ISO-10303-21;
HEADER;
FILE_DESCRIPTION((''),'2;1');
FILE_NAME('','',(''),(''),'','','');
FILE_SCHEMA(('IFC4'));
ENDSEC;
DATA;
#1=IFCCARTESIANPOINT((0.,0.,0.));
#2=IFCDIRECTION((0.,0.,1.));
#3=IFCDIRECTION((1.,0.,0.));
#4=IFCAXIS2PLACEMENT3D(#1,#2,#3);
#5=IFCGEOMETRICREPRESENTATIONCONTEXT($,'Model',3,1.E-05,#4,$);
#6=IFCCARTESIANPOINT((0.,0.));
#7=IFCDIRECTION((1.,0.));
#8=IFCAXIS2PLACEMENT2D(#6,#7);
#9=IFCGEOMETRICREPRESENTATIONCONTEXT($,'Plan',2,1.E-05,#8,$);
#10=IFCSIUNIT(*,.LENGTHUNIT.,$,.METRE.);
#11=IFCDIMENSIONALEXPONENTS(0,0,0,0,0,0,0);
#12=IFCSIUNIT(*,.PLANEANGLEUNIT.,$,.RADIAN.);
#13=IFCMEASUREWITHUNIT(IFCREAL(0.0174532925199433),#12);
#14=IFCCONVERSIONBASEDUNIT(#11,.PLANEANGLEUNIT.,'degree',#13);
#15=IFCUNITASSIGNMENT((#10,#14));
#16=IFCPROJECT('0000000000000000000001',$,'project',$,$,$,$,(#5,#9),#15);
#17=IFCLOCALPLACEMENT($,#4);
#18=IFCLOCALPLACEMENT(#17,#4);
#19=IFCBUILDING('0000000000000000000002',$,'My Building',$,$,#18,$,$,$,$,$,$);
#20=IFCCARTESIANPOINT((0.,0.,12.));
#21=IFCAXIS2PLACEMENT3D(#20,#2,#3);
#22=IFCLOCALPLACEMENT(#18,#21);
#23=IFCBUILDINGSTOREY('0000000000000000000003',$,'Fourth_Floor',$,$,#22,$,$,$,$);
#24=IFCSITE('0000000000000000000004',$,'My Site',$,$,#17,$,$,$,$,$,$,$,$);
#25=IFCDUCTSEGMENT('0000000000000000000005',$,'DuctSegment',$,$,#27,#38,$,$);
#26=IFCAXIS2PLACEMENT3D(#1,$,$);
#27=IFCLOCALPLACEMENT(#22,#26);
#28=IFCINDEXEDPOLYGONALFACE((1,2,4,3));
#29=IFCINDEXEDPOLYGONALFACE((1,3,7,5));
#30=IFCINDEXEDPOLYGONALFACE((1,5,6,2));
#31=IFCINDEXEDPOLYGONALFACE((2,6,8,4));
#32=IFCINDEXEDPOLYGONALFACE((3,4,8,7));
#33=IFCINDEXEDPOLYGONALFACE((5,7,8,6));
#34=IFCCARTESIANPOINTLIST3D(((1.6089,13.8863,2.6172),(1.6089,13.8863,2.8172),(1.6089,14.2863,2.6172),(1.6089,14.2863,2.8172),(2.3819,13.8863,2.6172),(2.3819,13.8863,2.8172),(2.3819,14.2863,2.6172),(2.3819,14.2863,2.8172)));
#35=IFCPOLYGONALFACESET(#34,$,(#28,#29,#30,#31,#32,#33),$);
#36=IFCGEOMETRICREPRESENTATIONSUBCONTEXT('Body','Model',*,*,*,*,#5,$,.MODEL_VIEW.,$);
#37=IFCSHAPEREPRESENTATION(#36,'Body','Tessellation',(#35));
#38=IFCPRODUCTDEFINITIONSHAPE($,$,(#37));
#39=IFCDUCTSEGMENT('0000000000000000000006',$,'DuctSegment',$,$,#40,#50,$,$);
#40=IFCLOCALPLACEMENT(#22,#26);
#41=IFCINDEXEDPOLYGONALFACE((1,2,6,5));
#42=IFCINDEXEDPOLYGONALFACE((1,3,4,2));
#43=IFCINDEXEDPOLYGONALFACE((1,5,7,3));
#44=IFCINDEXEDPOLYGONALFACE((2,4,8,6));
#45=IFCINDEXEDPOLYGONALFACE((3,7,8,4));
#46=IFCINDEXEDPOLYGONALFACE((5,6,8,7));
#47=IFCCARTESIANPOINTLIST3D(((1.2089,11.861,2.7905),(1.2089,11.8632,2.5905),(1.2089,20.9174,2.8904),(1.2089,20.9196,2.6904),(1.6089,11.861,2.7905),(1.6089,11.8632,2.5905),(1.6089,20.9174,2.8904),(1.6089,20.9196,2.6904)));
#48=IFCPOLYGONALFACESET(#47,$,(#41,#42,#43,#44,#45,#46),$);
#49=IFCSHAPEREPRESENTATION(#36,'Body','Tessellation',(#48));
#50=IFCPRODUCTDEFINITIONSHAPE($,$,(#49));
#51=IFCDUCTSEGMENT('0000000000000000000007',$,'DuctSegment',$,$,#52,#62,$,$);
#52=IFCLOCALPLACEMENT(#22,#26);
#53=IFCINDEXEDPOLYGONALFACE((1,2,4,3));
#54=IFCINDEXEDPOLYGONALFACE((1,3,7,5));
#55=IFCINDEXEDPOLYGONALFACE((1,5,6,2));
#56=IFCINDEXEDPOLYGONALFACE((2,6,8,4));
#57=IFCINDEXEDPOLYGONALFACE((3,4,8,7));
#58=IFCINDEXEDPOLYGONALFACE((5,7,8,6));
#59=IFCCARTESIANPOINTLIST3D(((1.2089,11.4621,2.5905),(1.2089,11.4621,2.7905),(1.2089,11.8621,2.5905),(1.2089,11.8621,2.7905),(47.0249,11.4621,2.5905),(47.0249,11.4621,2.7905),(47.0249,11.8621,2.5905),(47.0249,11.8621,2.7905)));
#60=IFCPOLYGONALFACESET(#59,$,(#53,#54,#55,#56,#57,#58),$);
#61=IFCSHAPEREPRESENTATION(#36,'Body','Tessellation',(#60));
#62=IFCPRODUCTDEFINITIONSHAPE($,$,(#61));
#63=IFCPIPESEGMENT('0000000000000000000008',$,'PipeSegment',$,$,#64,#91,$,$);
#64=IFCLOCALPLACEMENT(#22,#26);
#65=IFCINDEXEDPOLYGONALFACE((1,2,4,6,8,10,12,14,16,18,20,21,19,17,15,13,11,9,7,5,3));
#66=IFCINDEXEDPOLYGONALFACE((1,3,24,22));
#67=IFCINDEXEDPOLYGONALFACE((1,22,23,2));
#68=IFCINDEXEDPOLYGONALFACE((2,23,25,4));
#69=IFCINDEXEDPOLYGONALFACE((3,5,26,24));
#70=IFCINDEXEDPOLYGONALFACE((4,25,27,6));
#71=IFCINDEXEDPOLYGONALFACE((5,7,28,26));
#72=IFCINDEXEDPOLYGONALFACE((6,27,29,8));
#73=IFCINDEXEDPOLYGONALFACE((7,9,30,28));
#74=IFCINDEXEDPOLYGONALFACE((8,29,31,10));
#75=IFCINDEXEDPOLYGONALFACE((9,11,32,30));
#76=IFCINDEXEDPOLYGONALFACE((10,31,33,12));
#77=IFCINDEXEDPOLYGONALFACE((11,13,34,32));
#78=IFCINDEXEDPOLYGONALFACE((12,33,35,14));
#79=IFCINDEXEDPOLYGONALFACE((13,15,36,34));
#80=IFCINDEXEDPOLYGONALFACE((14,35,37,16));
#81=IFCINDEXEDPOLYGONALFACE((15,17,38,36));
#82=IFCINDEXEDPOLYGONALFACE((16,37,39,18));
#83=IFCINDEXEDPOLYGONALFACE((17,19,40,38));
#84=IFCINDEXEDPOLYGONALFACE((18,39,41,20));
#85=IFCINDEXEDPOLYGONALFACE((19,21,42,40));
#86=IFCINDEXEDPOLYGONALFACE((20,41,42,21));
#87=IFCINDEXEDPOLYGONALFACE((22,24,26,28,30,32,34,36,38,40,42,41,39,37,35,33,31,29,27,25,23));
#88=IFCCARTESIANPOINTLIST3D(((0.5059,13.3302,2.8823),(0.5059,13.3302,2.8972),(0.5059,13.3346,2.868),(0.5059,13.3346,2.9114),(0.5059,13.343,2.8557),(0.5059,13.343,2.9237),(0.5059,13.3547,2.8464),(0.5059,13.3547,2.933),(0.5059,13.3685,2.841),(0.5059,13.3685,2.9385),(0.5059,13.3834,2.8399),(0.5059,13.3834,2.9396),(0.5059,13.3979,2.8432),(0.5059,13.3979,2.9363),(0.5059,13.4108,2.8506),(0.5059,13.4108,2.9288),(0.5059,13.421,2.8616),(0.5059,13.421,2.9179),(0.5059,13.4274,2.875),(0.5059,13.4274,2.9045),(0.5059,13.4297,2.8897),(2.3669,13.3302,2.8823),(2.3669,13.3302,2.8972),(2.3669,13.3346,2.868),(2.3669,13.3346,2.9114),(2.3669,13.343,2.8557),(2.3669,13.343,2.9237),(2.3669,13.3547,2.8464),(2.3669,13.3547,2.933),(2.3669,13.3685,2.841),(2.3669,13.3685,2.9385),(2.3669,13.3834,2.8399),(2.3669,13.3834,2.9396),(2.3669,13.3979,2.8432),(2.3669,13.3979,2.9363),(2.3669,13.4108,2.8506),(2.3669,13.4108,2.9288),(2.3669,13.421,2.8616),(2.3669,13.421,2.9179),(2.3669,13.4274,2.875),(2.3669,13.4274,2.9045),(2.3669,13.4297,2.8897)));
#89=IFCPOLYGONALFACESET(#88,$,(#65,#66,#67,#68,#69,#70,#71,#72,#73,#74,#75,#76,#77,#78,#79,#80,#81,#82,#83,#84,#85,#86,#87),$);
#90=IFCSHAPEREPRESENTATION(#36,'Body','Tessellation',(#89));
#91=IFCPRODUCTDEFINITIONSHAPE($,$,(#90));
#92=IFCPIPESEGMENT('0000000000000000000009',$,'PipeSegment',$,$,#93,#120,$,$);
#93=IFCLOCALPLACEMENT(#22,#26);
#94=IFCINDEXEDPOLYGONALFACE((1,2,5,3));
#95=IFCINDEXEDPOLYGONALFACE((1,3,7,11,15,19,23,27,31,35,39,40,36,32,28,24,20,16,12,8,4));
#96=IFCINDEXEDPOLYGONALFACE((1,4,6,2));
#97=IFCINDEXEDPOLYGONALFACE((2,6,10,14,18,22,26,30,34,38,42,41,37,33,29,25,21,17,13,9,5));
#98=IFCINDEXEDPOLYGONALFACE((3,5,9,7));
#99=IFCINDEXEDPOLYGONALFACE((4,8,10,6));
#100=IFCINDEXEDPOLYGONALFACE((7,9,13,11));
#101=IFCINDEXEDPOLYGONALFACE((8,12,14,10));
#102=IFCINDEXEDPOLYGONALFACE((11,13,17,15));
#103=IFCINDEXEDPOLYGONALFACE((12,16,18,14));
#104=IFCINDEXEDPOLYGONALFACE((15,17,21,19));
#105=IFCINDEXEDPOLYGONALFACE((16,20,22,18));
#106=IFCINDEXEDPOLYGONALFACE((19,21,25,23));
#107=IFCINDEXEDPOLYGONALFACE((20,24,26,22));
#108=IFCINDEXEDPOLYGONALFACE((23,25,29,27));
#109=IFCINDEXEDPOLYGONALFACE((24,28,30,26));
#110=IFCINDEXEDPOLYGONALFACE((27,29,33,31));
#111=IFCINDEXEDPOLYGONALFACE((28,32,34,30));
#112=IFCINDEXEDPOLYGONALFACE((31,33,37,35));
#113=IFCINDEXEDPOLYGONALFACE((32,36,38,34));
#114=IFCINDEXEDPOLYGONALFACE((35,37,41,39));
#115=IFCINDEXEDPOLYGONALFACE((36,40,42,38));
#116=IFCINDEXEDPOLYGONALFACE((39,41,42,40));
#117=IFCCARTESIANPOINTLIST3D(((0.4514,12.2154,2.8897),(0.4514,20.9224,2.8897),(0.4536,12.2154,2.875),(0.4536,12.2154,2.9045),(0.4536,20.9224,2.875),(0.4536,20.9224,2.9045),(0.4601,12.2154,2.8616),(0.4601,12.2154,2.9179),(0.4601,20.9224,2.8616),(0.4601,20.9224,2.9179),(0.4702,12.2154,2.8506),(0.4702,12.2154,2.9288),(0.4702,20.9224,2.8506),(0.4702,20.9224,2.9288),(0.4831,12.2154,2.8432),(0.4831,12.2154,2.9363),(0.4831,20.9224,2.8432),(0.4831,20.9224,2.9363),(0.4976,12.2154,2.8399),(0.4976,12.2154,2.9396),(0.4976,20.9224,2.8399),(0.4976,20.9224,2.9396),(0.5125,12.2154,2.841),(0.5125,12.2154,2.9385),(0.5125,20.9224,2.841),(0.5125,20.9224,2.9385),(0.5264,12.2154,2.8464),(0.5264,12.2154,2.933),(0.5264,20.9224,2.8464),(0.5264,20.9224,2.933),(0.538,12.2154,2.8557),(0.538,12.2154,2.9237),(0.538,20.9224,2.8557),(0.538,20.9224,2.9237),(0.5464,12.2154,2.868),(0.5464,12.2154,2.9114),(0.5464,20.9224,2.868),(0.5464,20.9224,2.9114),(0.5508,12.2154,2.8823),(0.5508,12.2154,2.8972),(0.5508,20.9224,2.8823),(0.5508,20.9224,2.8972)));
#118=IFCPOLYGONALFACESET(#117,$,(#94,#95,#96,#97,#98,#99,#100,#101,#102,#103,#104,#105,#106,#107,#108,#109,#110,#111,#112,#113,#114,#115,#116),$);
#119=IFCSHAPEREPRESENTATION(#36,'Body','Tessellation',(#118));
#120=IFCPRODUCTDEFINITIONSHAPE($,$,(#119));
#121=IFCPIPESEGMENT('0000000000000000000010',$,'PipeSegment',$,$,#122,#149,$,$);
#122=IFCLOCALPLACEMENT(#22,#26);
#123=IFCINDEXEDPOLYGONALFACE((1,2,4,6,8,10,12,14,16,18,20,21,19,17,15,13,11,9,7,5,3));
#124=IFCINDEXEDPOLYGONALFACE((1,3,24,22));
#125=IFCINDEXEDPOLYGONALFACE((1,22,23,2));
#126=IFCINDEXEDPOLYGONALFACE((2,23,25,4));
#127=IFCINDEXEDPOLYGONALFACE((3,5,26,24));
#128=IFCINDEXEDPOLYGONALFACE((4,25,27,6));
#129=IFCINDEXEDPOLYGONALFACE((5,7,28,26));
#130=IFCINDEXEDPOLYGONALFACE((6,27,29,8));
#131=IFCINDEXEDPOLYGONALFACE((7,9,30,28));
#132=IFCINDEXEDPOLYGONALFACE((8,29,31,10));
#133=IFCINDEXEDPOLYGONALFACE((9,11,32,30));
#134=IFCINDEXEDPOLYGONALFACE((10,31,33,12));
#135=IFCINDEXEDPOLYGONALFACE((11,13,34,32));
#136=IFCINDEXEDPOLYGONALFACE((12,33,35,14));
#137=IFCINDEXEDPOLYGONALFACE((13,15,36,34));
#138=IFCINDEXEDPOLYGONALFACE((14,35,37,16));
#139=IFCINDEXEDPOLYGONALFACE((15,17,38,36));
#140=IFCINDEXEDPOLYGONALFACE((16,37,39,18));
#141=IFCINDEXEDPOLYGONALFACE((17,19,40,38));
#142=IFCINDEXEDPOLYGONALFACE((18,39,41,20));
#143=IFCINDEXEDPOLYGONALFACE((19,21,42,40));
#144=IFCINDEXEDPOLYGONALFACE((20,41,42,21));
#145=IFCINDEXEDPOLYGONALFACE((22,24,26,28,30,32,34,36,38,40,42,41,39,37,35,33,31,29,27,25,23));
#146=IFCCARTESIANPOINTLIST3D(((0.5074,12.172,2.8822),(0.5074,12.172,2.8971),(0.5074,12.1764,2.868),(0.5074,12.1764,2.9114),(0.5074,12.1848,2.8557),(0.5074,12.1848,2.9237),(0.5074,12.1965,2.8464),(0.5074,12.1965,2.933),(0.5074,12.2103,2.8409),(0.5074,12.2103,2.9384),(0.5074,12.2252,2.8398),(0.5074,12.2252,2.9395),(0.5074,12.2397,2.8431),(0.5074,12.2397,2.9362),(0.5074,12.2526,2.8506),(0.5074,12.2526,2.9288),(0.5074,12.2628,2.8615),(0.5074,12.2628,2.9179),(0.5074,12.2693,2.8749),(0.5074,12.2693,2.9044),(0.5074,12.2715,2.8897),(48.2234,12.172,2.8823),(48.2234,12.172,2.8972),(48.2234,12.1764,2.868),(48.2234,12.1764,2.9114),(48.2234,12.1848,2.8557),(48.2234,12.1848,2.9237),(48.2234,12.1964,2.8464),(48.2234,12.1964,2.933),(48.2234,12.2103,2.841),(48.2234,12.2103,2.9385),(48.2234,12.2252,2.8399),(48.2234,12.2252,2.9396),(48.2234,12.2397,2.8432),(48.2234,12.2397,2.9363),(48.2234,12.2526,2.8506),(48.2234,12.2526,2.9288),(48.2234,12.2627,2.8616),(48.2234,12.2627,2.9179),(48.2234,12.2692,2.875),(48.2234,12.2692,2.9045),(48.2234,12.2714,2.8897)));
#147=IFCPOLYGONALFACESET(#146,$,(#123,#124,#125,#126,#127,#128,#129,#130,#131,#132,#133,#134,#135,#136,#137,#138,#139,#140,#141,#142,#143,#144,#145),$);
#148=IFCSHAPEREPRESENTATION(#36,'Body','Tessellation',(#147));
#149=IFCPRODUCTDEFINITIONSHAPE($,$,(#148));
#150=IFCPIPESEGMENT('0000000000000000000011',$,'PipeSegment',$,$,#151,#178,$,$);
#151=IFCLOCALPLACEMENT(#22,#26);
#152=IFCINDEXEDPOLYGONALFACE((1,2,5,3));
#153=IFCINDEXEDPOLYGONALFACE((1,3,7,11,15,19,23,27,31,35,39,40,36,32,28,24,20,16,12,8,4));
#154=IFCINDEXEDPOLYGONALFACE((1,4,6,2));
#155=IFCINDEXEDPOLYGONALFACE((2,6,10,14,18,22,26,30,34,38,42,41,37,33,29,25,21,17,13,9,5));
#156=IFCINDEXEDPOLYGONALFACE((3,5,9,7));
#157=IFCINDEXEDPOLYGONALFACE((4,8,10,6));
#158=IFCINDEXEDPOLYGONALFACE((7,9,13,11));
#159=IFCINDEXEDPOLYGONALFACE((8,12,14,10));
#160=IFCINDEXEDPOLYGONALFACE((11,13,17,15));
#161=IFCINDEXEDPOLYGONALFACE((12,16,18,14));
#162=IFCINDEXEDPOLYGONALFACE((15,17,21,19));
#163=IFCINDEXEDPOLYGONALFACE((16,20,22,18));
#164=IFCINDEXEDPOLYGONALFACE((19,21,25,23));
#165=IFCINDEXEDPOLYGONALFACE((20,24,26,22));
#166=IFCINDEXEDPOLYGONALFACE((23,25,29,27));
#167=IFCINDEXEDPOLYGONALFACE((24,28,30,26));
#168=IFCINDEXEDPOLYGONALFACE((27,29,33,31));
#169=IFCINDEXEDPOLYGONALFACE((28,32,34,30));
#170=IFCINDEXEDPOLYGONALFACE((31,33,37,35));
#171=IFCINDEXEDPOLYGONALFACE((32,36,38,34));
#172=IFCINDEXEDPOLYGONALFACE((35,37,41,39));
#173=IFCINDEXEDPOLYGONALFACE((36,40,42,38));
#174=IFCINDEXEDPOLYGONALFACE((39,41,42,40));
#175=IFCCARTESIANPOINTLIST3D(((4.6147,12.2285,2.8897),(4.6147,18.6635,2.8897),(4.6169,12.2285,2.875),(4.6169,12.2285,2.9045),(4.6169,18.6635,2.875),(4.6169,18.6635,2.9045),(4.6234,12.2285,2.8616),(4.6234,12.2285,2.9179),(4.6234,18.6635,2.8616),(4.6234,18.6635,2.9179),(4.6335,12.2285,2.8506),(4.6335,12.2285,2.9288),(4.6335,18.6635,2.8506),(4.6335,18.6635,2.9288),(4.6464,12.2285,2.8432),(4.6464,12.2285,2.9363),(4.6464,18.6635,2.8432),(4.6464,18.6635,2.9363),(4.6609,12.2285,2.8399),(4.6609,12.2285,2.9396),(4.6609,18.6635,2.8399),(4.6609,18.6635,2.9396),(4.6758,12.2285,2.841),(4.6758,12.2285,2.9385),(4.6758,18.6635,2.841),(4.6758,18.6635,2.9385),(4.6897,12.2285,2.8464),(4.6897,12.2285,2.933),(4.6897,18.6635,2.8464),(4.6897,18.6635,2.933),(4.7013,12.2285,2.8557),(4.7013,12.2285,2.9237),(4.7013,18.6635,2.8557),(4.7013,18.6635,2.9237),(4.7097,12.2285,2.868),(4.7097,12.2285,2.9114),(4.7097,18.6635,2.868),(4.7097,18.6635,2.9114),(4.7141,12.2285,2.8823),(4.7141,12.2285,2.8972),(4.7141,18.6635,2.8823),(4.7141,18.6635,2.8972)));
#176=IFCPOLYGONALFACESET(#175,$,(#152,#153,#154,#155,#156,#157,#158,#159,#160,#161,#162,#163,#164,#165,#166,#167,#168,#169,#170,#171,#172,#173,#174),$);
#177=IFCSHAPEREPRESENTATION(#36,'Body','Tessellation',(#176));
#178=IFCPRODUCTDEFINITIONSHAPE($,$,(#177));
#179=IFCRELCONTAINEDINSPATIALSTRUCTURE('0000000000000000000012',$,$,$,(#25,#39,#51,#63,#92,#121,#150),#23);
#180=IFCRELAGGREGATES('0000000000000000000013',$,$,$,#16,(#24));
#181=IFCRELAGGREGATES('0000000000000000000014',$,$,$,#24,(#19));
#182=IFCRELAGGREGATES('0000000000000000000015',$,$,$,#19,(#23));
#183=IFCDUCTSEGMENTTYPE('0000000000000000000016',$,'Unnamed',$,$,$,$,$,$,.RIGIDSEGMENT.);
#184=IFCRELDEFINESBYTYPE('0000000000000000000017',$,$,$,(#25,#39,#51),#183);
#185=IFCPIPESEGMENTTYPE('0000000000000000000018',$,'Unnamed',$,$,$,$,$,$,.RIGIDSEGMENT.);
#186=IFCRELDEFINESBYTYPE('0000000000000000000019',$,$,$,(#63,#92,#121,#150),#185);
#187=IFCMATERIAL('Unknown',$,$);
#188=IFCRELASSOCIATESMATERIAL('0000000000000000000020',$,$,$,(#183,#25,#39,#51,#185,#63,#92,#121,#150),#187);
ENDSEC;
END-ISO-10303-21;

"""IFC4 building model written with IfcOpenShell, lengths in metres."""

from ifc_helpers import new_model, entity, si_unit, converted_unit, frame, origin_with_axes, origin_2d_with_axis, place, context, subcontext, project, spatial, rectangle, circle, extrude, material, material_profile, profile_set, profile_usage, type_object, element, save


model = new_model("IFC4")

# Units and contexts
model_context = context("Model", 3, precision=1e-05, world=origin_with_axes())
plan_context = context("Plan", 2, precision=1e-05, world=origin_2d_with_axis())
body_context_1 = subcontext(model_context, "Body", "Model", "MODEL_VIEW")
ifc_project = project(units=[si_unit("LENGTHUNIT", "METRE"), converted_unit("PLANEANGLEUNIT", "degree", entity("IfcReal", 0.0174532925199433), si_unit("PLANEANGLEUNIT", "RADIAN"), dimensions=[0, 0, 0, 0, 0, 0, 0])], contexts=[model_context, plan_context])

# Site, building, storey
site_placement = place(None, origin_with_axes())
site = spatial("IfcSite", under=ifc_project, at=site_placement, Name="My Site")
building_placement = place(site_placement, origin_with_axes())
building = spatial("IfcBuilding", under=site, at=building_placement, Name="My Building")
storey_placement = place(building_placement, frame((0.0, 0.0, 12.0), z_axis=(0.0, 0.0, 1.0), x_axis=(1.0, 0.0, 0.0)))
storey = spatial("IfcBuildingStorey", under=building, at=storey_placement, Name="Fourth_Floor")

# Shared definitions
ifc_material = material(Name="Unknown")

# Duct segments
ifc_material_profile_1 = material_profile(ifc_material, rectangle(XDim=0.4, YDim=0.2))
ifc_profile_set_1 = profile_set([ifc_material_profile_1])
ifc_profile_usage_1 = profile_usage(ifc_profile_set_1, cardinal=5)
duct_segment_type = type_object("IfcDuctSegmentType", Name="Unnamed", PredefinedType="RIGIDSEGMENT", material=ifc_profile_set_1)
duct_segment_1_placement = place(storey_placement, frame((1.6089, 14.0863, 2.7172), z_axis=(1.0, -0.000001, 0.000001), x_axis=(0.000001, 1.0, 0.0)))
element("IfcDuctSegment", 1, at=duct_segment_1_placement, inside=storey, type_object=duct_segment_type, material=ifc_profile_usage_1, Name="DuctSegment", context=body_context_1, shape_type="SweptSolid", body=[
    extrude(rectangle(XDim=0.4, YDim=0.2), origin_with_axes(), (0.0, 0.0, 1.0), 0.773),
])
ifc_profile_usage_2 = profile_usage(ifc_profile_set_1, cardinal=5)
duct_segment_2_placement = place(storey_placement, frame((1.4089, 11.8621, 2.6905), z_axis=(0.0, 0.999939, 0.011037), x_axis=(-1.0, 0.0, 0.0)))
element("IfcDuctSegment", 2, at=duct_segment_2_placement, inside=storey, type_object=duct_segment_type, material=ifc_profile_usage_2, Name="DuctSegment", context=body_context_1, shape_type="SweptSolid", body=[
    extrude(rectangle(XDim=0.4, YDim=0.2), origin_with_axes(), (0.0, 0.0, 1.0), 9.057),
])
ifc_profile_usage_3 = profile_usage(ifc_profile_set_1, cardinal=5)
duct_segment_3_placement = place(storey_placement, frame((1.2089, 11.6621, 2.6905), z_axis=(1.0, 0.0, 0.0), x_axis=(0.0, 1.0, 0.0)))
element("IfcDuctSegment", 3, at=duct_segment_3_placement, inside=storey, type_object=duct_segment_type, material=ifc_profile_usage_3, Name="DuctSegment", context=body_context_1, shape_type="SweptSolid", body=[
    extrude(rectangle(XDim=0.4, YDim=0.2), origin_with_axes(), (0.0, 0.0, 1.0), 45.816),
])

# Pipe segments
ifc_material_profile_2 = material_profile(ifc_material, circle(Radius=0.05))
ifc_profile_set_2 = profile_set([ifc_material_profile_2])
ifc_profile_usage_4 = profile_usage(ifc_profile_set_2, cardinal=5)
pipe_segment_type = type_object("IfcPipeSegmentType", Name="Unnamed", PredefinedType="RIGIDSEGMENT", material=ifc_profile_set_2)
pipe_segment_1_placement = place(storey_placement, frame((0.5059, 13.3797, 2.8897), z_axis=(1.0, 0.0, 0.0), x_axis=(0.0, 1.0, 0.0)))
element("IfcPipeSegment", 4, at=pipe_segment_1_placement, inside=storey, type_object=pipe_segment_type, material=ifc_profile_usage_4, Name="PipeSegment", context=body_context_1, shape_type="SweptSolid", body=[
    extrude(circle(Radius=0.05), origin_with_axes(), (0.0, 0.0, 1.0), 1.861),
])
ifc_profile_usage_5 = profile_usage(ifc_profile_set_2, cardinal=5)
pipe_segment_2_placement = place(storey_placement, frame((0.5014, 12.2154, 2.8897), z_axis=(0.0, 1.0, 0.0), x_axis=(-1.0, 0.0, 0.0)))
element("IfcPipeSegment", 5, at=pipe_segment_2_placement, inside=storey, type_object=pipe_segment_type, material=ifc_profile_usage_5, Name="PipeSegment", context=body_context_1, shape_type="SweptSolid", body=[
    extrude(circle(Radius=0.05), origin_with_axes(), (0.0, 0.0, 1.0), 8.707),
])
ifc_profile_usage_6 = profile_usage(ifc_profile_set_2, cardinal=5)
pipe_segment_3_placement = place(storey_placement, frame((0.5074, 12.2215, 2.8897), z_axis=(1.0, -0.000001, 0.000001), x_axis=(0.000001, 1.0, 0.0)))
element("IfcPipeSegment", 6, at=pipe_segment_3_placement, inside=storey, type_object=pipe_segment_type, material=ifc_profile_usage_6, Name="PipeSegment", context=body_context_1, shape_type="SweptSolid", body=[
    extrude(circle(Radius=0.05), origin_with_axes(), (0.0, 0.0, 1.0), 47.716),
])
ifc_profile_usage_7 = profile_usage(ifc_profile_set_2, cardinal=5)
pipe_segment_4_placement = place(storey_placement, frame((4.6647, 12.2285, 2.8897), z_axis=(0.0, 1.0, 0.0), x_axis=(-1.0, 0.0, 0.0)))
element("IfcPipeSegment", 7, at=pipe_segment_4_placement, inside=storey, type_object=pipe_segment_type, material=ifc_profile_usage_7, Name="PipeSegment", context=body_context_1, shape_type="SweptSolid", body=[
    extrude(circle(Radius=0.05), origin_with_axes(), (0.0, 0.0, 1.0), 6.435),
])

save(model, "model.ifc")
